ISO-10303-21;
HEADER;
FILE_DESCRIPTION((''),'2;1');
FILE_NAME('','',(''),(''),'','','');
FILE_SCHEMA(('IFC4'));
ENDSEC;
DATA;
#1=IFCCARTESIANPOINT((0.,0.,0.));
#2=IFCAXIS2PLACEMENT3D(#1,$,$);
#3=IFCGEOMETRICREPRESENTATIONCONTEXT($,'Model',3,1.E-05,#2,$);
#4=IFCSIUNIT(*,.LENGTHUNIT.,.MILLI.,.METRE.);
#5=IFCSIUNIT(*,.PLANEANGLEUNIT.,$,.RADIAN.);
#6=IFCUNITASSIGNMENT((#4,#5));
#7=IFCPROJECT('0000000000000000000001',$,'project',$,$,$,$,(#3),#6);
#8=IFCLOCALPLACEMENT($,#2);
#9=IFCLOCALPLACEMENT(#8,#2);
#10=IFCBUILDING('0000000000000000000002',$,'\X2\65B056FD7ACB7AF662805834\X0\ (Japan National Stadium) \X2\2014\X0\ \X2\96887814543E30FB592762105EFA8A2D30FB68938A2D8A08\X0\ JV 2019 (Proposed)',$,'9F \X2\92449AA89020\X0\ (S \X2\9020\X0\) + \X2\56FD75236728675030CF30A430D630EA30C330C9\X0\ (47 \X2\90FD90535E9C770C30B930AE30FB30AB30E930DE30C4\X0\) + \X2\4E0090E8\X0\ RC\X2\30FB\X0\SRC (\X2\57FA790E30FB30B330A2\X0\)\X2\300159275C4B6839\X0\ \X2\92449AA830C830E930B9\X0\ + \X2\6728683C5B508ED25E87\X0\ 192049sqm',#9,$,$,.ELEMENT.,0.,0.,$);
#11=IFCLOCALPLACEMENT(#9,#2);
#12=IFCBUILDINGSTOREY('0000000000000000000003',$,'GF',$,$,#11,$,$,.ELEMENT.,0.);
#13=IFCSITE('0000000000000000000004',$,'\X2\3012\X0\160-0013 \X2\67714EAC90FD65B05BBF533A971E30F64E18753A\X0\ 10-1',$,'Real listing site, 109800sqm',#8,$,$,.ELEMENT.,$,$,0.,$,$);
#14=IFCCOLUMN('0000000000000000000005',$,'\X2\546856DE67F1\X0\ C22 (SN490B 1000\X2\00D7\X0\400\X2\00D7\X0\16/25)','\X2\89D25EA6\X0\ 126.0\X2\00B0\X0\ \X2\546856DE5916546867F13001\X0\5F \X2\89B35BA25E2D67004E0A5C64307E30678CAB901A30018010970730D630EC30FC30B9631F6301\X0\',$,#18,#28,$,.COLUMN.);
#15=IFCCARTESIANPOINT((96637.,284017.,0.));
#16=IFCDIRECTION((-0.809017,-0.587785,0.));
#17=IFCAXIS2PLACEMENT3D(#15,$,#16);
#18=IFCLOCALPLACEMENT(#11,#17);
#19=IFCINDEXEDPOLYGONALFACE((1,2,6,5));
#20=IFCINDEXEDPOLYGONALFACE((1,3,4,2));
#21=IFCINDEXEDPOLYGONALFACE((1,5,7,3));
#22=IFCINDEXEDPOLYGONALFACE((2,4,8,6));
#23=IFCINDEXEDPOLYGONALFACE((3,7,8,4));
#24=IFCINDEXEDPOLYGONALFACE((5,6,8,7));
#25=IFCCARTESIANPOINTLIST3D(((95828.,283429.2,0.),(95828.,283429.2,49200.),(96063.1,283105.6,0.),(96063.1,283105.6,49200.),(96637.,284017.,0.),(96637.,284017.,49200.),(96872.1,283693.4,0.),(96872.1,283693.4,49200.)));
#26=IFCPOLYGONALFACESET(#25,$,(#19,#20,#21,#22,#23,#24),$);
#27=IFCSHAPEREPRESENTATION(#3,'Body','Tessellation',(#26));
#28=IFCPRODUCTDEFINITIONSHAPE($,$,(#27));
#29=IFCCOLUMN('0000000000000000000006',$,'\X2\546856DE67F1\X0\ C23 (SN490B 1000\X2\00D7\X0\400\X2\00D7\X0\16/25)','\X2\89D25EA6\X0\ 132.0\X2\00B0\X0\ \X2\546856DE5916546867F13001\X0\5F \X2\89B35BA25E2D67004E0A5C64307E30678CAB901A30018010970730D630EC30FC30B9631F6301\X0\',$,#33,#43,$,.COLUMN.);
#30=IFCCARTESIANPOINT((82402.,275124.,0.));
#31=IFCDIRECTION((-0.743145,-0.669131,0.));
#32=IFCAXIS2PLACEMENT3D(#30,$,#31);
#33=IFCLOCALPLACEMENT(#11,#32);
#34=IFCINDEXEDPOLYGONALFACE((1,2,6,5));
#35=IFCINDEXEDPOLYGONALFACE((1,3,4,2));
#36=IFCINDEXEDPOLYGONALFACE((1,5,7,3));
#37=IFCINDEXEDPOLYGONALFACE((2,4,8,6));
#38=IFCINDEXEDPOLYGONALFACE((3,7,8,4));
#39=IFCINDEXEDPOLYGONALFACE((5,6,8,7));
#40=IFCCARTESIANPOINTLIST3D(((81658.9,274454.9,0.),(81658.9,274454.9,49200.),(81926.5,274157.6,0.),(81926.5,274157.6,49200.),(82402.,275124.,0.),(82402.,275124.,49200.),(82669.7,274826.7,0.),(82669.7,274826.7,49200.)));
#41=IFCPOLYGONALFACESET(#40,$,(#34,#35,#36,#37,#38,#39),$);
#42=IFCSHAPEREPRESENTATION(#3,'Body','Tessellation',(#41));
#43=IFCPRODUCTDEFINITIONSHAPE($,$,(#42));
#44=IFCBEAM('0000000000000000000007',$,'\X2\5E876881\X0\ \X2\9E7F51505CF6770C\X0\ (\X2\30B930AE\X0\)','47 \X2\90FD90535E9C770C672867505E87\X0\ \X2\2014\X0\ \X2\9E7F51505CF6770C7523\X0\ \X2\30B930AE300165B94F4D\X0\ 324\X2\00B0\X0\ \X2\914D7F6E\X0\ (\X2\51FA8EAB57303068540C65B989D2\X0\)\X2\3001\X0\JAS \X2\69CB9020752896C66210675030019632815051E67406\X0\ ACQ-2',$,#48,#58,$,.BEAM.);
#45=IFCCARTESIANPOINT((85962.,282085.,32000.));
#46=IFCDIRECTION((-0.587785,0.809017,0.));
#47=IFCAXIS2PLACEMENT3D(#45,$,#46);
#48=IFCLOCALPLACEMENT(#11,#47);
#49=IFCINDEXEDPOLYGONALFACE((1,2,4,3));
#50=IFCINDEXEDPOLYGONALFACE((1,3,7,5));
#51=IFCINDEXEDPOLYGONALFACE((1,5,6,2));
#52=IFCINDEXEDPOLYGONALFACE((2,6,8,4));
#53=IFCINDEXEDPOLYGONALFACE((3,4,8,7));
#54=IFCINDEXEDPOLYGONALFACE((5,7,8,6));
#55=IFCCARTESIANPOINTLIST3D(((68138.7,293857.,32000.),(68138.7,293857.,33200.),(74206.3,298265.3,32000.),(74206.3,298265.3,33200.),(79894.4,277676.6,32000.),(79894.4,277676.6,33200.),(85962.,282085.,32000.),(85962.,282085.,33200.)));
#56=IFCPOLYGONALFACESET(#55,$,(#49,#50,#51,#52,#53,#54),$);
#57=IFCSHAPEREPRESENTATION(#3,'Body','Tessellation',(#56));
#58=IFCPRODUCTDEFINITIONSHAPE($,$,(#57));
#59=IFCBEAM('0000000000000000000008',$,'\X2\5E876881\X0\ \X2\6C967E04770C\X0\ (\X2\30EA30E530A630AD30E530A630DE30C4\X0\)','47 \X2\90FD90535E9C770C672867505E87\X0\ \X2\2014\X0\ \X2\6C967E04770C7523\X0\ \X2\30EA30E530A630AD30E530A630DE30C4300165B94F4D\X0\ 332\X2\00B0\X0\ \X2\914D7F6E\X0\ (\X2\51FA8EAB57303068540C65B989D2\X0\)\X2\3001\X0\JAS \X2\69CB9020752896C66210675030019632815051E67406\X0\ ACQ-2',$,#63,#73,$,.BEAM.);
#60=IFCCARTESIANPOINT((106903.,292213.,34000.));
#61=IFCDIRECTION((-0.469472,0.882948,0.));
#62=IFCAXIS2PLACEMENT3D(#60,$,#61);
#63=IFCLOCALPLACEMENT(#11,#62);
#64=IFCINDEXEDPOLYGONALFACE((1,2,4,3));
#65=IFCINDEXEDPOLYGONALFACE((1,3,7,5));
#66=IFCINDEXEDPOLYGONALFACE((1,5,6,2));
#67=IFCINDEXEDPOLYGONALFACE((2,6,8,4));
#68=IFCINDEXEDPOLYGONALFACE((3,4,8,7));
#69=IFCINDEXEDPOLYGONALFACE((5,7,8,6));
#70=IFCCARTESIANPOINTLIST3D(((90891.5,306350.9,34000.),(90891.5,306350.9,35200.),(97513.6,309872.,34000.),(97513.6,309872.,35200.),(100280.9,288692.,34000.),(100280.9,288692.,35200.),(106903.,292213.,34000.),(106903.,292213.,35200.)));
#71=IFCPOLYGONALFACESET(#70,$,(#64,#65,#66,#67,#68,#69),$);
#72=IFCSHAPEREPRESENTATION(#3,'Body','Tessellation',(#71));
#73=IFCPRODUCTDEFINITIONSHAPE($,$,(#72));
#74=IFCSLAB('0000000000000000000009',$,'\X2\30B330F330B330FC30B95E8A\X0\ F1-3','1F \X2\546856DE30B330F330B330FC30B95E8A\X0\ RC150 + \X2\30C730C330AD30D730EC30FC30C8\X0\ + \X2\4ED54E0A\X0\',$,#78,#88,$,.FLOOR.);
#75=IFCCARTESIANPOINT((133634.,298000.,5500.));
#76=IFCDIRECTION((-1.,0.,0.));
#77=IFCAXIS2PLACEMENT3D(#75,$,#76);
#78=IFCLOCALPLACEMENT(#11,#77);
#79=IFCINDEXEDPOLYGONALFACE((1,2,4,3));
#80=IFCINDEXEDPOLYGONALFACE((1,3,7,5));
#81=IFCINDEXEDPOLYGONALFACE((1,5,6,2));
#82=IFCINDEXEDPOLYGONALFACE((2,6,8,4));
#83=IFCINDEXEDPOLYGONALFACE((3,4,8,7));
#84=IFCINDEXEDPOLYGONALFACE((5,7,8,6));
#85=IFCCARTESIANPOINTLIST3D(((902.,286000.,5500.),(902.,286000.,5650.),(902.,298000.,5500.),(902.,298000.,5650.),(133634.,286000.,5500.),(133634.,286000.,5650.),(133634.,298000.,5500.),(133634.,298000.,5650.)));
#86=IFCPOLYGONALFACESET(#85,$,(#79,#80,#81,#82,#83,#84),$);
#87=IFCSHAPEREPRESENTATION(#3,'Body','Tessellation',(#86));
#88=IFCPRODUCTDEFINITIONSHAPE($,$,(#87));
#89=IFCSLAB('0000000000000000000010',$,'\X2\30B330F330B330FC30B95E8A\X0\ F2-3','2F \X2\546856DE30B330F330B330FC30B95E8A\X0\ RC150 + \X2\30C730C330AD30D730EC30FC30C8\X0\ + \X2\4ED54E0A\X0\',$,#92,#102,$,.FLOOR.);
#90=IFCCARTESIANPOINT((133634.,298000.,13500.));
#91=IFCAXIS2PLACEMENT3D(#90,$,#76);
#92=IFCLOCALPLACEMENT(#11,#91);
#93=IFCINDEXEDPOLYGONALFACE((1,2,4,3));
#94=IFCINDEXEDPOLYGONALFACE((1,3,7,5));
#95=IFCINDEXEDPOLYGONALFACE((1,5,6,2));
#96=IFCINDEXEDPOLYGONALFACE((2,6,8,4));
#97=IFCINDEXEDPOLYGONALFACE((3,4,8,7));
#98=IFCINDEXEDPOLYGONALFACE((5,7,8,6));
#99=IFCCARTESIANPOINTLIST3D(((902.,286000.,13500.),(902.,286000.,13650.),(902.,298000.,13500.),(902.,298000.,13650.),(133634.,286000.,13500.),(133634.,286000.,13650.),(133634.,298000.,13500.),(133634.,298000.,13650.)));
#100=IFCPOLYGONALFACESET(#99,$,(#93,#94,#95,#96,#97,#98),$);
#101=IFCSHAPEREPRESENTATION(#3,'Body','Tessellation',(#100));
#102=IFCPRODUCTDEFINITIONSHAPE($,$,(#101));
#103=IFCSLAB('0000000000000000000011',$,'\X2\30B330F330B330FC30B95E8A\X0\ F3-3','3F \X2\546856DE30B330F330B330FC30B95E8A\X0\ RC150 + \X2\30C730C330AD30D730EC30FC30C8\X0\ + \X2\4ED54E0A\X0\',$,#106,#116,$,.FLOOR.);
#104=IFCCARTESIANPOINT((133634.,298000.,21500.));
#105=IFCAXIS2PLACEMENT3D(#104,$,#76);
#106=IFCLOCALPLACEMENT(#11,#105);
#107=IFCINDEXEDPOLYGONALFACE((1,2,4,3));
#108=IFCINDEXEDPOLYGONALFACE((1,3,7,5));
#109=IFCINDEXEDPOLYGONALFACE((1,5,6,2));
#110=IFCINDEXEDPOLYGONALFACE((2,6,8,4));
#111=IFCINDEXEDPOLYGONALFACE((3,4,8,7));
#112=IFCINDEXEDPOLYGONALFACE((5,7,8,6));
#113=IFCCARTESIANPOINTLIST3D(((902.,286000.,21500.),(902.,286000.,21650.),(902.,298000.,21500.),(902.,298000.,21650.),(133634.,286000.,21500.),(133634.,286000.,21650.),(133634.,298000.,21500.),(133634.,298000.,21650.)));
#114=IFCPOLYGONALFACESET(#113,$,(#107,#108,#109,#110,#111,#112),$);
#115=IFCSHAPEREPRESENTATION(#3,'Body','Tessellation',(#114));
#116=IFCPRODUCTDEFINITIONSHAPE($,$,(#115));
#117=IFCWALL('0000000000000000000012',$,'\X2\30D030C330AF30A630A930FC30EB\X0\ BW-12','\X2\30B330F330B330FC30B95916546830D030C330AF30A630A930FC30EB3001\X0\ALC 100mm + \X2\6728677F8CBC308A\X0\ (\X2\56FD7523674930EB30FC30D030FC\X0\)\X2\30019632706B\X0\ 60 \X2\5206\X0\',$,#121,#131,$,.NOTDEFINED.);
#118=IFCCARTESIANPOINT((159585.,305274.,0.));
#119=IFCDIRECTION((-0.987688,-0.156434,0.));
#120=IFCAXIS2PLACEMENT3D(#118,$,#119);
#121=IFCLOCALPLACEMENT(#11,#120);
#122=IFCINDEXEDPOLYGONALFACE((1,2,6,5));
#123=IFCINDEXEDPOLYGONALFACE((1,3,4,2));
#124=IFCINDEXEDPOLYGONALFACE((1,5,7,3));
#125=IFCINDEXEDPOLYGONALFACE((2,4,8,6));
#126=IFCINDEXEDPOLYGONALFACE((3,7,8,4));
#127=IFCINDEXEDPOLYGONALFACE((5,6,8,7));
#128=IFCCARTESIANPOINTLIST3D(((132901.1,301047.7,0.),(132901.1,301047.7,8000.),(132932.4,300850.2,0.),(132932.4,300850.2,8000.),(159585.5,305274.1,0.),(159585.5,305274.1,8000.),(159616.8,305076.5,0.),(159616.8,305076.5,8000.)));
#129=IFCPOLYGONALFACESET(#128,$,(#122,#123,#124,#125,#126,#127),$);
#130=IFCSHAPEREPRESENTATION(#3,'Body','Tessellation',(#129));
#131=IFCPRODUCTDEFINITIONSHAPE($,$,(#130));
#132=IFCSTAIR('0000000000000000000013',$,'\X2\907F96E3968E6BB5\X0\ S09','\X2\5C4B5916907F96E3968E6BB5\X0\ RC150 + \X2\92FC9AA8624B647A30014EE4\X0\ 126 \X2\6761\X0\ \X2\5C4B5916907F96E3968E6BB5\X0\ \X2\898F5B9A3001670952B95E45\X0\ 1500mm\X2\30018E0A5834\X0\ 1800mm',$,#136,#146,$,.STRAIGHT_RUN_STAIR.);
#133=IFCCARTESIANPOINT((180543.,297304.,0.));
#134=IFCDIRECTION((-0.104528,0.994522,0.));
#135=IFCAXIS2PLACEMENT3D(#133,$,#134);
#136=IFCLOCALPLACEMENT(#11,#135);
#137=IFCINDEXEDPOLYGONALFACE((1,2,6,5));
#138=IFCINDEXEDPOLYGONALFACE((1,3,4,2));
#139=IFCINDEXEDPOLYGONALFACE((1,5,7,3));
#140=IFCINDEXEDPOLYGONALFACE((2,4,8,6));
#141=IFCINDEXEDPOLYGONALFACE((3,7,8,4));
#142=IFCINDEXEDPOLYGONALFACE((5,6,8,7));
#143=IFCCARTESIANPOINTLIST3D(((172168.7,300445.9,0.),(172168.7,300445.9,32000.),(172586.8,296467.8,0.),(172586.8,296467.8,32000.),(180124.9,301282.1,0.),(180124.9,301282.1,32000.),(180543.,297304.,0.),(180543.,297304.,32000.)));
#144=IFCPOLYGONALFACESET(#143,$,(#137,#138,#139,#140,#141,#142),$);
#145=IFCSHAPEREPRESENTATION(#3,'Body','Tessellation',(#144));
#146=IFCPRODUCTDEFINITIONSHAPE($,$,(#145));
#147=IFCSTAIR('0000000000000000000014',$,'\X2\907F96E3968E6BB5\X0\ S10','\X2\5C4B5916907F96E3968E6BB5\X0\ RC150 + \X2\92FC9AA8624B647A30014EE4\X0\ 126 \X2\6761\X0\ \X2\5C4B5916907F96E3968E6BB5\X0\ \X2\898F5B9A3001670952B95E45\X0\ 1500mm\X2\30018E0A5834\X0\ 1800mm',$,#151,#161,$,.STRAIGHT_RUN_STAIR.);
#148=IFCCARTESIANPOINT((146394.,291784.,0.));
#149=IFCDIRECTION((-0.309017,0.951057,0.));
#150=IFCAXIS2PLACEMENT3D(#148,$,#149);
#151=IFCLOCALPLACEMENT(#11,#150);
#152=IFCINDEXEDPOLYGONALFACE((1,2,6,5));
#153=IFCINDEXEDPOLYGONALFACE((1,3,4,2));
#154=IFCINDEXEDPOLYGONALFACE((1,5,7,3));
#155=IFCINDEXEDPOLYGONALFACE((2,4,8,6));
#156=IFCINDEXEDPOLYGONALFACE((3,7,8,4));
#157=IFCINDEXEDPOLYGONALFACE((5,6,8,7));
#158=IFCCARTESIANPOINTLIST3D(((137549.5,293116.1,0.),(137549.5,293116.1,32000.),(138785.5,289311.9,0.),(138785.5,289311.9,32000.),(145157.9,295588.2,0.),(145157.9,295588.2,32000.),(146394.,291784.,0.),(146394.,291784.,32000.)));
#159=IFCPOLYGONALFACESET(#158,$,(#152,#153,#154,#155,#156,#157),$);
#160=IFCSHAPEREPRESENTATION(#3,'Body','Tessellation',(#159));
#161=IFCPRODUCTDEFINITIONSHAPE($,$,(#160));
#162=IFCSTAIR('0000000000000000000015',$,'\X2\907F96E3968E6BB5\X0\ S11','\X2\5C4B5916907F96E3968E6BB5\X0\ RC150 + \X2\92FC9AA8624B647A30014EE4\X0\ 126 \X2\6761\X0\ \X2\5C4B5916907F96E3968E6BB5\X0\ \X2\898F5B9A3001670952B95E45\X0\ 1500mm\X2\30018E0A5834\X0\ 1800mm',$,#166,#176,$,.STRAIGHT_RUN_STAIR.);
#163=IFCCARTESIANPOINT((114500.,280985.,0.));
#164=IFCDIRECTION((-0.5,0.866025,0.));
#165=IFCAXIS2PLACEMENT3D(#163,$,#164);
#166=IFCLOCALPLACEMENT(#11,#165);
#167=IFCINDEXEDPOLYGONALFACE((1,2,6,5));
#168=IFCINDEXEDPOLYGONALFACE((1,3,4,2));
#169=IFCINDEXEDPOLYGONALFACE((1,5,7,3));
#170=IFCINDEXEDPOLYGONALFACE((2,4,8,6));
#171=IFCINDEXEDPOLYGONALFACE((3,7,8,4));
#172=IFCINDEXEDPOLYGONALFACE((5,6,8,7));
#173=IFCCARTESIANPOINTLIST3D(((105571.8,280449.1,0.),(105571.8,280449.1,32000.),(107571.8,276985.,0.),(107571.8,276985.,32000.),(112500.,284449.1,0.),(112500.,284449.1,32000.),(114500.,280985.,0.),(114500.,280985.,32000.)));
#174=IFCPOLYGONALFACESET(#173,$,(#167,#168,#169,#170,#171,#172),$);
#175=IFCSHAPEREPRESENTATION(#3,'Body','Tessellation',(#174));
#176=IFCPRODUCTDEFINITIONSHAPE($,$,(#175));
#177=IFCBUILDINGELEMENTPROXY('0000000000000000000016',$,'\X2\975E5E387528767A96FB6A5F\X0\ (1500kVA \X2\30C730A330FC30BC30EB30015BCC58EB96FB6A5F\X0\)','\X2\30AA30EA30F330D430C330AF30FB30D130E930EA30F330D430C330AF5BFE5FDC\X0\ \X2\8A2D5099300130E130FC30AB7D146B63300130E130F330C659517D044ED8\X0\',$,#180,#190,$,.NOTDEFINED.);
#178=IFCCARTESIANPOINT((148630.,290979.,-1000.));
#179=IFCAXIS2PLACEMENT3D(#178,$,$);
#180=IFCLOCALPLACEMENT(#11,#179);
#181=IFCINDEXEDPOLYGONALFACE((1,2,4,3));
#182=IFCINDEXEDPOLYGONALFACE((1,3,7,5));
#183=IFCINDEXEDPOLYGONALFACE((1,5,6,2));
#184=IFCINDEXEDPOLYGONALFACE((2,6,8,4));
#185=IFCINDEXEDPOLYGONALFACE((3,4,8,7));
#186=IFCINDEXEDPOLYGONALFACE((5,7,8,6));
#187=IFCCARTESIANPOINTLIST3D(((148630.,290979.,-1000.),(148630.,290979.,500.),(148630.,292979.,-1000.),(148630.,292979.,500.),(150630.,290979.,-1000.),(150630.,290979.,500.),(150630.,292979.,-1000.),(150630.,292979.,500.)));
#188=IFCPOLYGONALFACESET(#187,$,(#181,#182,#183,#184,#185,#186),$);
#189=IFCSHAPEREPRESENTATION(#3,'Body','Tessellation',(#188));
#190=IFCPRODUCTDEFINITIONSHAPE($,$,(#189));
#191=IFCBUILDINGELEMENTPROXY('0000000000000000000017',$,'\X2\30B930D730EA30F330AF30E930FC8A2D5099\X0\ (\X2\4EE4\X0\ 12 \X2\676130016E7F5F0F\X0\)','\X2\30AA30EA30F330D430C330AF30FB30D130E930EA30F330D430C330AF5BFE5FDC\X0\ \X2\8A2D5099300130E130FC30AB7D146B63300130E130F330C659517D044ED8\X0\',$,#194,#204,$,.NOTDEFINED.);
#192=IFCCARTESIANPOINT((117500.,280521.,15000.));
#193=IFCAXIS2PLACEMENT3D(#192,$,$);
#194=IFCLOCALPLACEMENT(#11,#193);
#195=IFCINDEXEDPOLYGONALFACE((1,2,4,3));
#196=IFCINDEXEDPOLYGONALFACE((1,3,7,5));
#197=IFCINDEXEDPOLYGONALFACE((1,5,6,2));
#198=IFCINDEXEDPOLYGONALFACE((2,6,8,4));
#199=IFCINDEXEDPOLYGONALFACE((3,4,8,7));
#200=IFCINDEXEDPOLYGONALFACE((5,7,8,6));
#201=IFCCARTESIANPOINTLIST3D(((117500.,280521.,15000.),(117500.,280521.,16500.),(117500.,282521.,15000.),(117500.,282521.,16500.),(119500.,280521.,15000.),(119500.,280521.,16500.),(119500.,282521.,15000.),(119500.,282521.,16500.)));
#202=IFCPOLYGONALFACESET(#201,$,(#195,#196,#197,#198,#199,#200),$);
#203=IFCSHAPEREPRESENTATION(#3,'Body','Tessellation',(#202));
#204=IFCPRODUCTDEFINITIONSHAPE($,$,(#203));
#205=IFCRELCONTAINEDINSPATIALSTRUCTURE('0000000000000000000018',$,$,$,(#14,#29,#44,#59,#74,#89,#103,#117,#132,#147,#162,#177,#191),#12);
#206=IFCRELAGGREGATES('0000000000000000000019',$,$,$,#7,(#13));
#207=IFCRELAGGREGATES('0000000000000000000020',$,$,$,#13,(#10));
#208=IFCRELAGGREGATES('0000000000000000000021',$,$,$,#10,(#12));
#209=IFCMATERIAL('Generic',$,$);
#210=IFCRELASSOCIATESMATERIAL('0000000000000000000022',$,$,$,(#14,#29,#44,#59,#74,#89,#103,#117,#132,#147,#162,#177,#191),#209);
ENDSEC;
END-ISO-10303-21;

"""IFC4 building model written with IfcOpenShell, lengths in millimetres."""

from ifc_helpers import new_model, si_unit, frame, frame_2d, origin, place, context, project, spatial, rectangle, extrude, material, element, save


model = new_model("IFC4")

# Units and contexts
model_context = context("Model", 3, precision=1e-05, world=origin())
ifc_project = project(units=[si_unit("LENGTHUNIT", "METRE", prefix="MILLI"), si_unit("PLANEANGLEUNIT", "RADIAN")], contexts=[model_context])

# Site, building, storey
site_placement = place(None, origin())
site = spatial("IfcSite", under=ifc_project, at=site_placement, Name="〒160-0013 東京都新宿区霞ヶ丘町 10-1", ObjectType="Real listing site, 109800sqm", CompositionType="ELEMENT", RefElevation=0.0)
building_placement = place(site_placement, origin())
building = spatial("IfcBuilding", under=site, at=building_placement, Name="新国立競技場 (Japan National Stadium) — 隈研吾・大成建設・梓設計 JV 2019 (Proposed)", ObjectType="9F 鉄骨造 (S 造) + 国産木材ハイブリッド (47 都道府県スギ・カラマツ) + 一部 RC・SRC (基礎・コア)、大屋根 鉄骨トラス + 木格子軒庇 192049sqm", CompositionType="ELEMENT", ElevationOfRefHeight=0.0, ElevationOfTerrain=0.0)
storey_placement = place(building_placement, origin())
storey = spatial("IfcBuildingStorey", under=building, at=storey_placement, Name="GF", CompositionType="ELEMENT", Elevation=0.0)

# Columns
ifc_material_1 = material(Name="Generic")
column_1_placement = place(storey_placement, frame((96637.0, 284017.0, 0.0), x_axis=(-0.809017, -0.587785, 0.0)))
element("IfcColumn", 1, at=column_1_placement, inside=storey, material=ifc_material_1, Name="周回柱 C22 (SN490B 1000×400×16/25)", Description="角度 126.0° 周回外周柱、5F 観客席最上層まで貫通、耐震ブレース挟持", PredefinedType="COLUMN", context=model_context, shape_type="SweptSolid", body=[
    extrude(rectangle(XDim=1000.0, YDim=400.0, at=frame_2d((500.0, 200.0))), frame((96637.0, 284017.0, 0.0), x_axis=(-0.809017, -0.587785, 0.0)), (0.0, 0.0, 1.0), 49200.0),
])
column_2_placement = place(storey_placement, frame((82402.0, 275124.0, 0.0), x_axis=(-0.743145, -0.669131, 0.0)))
element("IfcColumn", 2, at=column_2_placement, inside=storey, material=ifc_material_1, Name="周回柱 C23 (SN490B 1000×400×16/25)", Description="角度 132.0° 周回外周柱、5F 観客席最上層まで貫通、耐震ブレース挟持", PredefinedType="COLUMN", context=model_context, shape_type="SweptSolid", body=[
    extrude(rectangle(XDim=1000.0, YDim=400.0, at=frame_2d((500.0, 200.0))), frame((82402.0, 275124.0, 0.0), x_axis=(-0.743145, -0.669131, 0.0)), (0.0, 0.0, 1.0), 49200.0),
])

# Beams
beam_1_placement = place(storey_placement, frame((85962.0, 282085.0, 32000.0), x_axis=(-0.587785, 0.809017, 0.0)))
element("IfcBeam", 3, at=beam_1_placement, inside=storey, material=ifc_material_1, Name="庇梁 鹿児島県 (スギ)", Description="47 都道府県木材庇 — 鹿児島県産 スギ、方位 324° 配置 (出身地と同方角)、JAS 構造用集成材、防腐処理 ACQ-2", PredefinedType="BEAM", context=model_context, shape_type="SweptSolid", body=[
    extrude(rectangle(XDim=20000.0, YDim=7500.0, at=frame_2d((10000.0, 3750.0))), frame((85962.0, 282085.0, 32000.0), x_axis=(-0.587785, 0.809017, 0.0)), (0.0, 0.0, 1.0), 1200.0),
])
beam_2_placement = place(storey_placement, frame((106903.0, 292213.0, 34000.0), x_axis=(-0.469472, 0.882948, 0.0)))
element("IfcBeam", 4, at=beam_2_placement, inside=storey, material=ifc_material_1, Name="庇梁 沖縄県 (リュウキュウマツ)", Description="47 都道府県木材庇 — 沖縄県産 リュウキュウマツ、方位 332° 配置 (出身地と同方角)、JAS 構造用集成材、防腐処理 ACQ-2", PredefinedType="BEAM", context=model_context, shape_type="SweptSolid", body=[
    extrude(rectangle(XDim=20000.0, YDim=7500.0, at=frame_2d((10000.0, 3750.0))), frame((106903.0, 292213.0, 34000.0), x_axis=(-0.469472, 0.882948, 0.0)), (0.0, 0.0, 1.0), 1200.0),
])

# Slabs
slab_1_placement = place(storey_placement, frame((133634.0, 298000.0, 5500.0), x_axis=(-1.0, 0.0, 0.0)))
element("IfcSlab", 5, at=slab_1_placement, inside=storey, material=ifc_material_1, Name="コンコース床 F1-3", Description="1F 周回コンコース床 RC150 + デッキプレート + 仕上", PredefinedType="FLOOR", context=model_context, shape_type="SweptSolid", body=[
    extrude(rectangle(XDim=132732.0, YDim=12000.0, at=frame_2d((66366.0, 6000.0))), frame((133634.0, 298000.0, 5500.0), x_axis=(-1.0, 0.0, 0.0)), (0.0, 0.0, 1.0), 150.0),
])
slab_2_placement = place(storey_placement, frame((133634.0, 298000.0, 13500.0), x_axis=(-1.0, 0.0, 0.0)))
element("IfcSlab", 6, at=slab_2_placement, inside=storey, material=ifc_material_1, Name="コンコース床 F2-3", Description="2F 周回コンコース床 RC150 + デッキプレート + 仕上", PredefinedType="FLOOR", context=model_context, shape_type="SweptSolid", body=[
    extrude(rectangle(XDim=132732.0, YDim=12000.0, at=frame_2d((66366.0, 6000.0))), frame((133634.0, 298000.0, 13500.0), x_axis=(-1.0, 0.0, 0.0)), (0.0, 0.0, 1.0), 150.0),
])
slab_3_placement = place(storey_placement, frame((133634.0, 298000.0, 21500.0), x_axis=(-1.0, 0.0, 0.0)))
element("IfcSlab", 7, at=slab_3_placement, inside=storey, material=ifc_material_1, Name="コンコース床 F3-3", Description="3F 周回コンコース床 RC150 + デッキプレート + 仕上", PredefinedType="FLOOR", context=model_context, shape_type="SweptSolid", body=[
    extrude(rectangle(XDim=132732.0, YDim=12000.0, at=frame_2d((66366.0, 6000.0))), frame((133634.0, 298000.0, 21500.0), x_axis=(-1.0, 0.0, 0.0)), (0.0, 0.0, 1.0), 150.0),
])

# Wall
wall_1_placement = place(storey_placement, frame((159585.0, 305274.0, 0.0), x_axis=(-0.987688, -0.156434, 0.0)))
element("IfcWall", 8, at=wall_1_placement, inside=storey, material=ifc_material_1, Name="バックウォール BW-12", Description="コンコース外周バックウォール、ALC 100mm + 木板貼り (国産杉ルーバー)、防火 60 分", PredefinedType="NOTDEFINED", context=model_context, shape_type="SweptSolid", body=[
    extrude(rectangle(XDim=27017.0, YDim=200.0, at=frame_2d((13508.0, 100.0))), frame((159585.0, 305274.0, 0.0), x_axis=(-0.987688, -0.156434, 0.0)), (0.0, 0.0, 1.0), 8000.0),
])

# Stairs
stair_1_placement = place(storey_placement, frame((180543.0, 297304.0, 0.0), x_axis=(-0.104528, 0.994522, 0.0)))
element("IfcStair", 9, at=stair_1_placement, inside=storey, material=ifc_material_1, Name="避難階段 S09", Description="屋外避難階段 RC150 + 鋼骨手摺、令 126 条 屋外避難階段 規定、有効幅 1500mm、踊場 1800mm", PredefinedType="STRAIGHT_RUN_STAIR", context=model_context, shape_type="SweptSolid", body=[
    extrude(rectangle(XDim=4000.0, YDim=8000.0, at=frame_2d((2000.0, 4000.0))), frame((180543.0, 297304.0, 0.0), x_axis=(-0.104528, 0.994522, 0.0)), (0.0, 0.0, 1.0), 32000.0),
])
stair_2_placement = place(storey_placement, frame((146394.0, 291784.0, 0.0), x_axis=(-0.309017, 0.951057, 0.0)))
element("IfcStair", 10, at=stair_2_placement, inside=storey, material=ifc_material_1, Name="避難階段 S10", Description="屋外避難階段 RC150 + 鋼骨手摺、令 126 条 屋外避難階段 規定、有効幅 1500mm、踊場 1800mm", PredefinedType="STRAIGHT_RUN_STAIR", context=model_context, shape_type="SweptSolid", body=[
    extrude(rectangle(XDim=4000.0, YDim=8000.0, at=frame_2d((2000.0, 4000.0))), frame((146394.0, 291784.0, 0.0), x_axis=(-0.309017, 0.951057, 0.0)), (0.0, 0.0, 1.0), 32000.0),
])
stair_3_placement = place(storey_placement, frame((114500.0, 280985.0, 0.0), x_axis=(-0.5, 0.866025, 0.0)))
element("IfcStair", 11, at=stair_3_placement, inside=storey, material=ifc_material_1, Name="避難階段 S11", Description="屋外避難階段 RC150 + 鋼骨手摺、令 126 条 屋外避難階段 規定、有効幅 1500mm、踊場 1800mm", PredefinedType="STRAIGHT_RUN_STAIR", context=model_context, shape_type="SweptSolid", body=[
    extrude(rectangle(XDim=4000.0, YDim=8000.0, at=frame_2d((2000.0, 4000.0))), frame((114500.0, 280985.0, 0.0), x_axis=(-0.5, 0.866025, 0.0)), (0.0, 0.0, 1.0), 32000.0),
])

# Building element proxies
proxy_1_placement = place(storey_placement, frame((148630.0, 290979.0, -1000.0)))
element("IfcBuildingElementProxy", 12, at=proxy_1_placement, inside=storey, material=ifc_material_1, Name="非常用発電機 (1500kVA ディーゼル、富士電機)", Description="オリンピック・パラリンピック対応 設備、メーカ純正、メンテ契約付", PredefinedType="NOTDEFINED", context=model_context, shape_type="SweptSolid", body=[
    extrude(rectangle(XDim=2000.0, YDim=2000.0, at=frame_2d((1000.0, 1000.0))), frame((148630.0, 290979.0, -1000.0)), (0.0, 0.0, 1.0), 1500.0),
])
proxy_2_placement = place(storey_placement, frame((117500.0, 280521.0, 15000.0)))
element("IfcBuildingElementProxy", 13, at=proxy_2_placement, inside=storey, material=ifc_material_1, Name="スプリンクラー設備 (令 12 条、湿式)", Description="オリンピック・パラリンピック対応 設備、メーカ純正、メンテ契約付", PredefinedType="NOTDEFINED", context=model_context, shape_type="SweptSolid", body=[
    extrude(rectangle(XDim=2000.0, YDim=2000.0, at=frame_2d((1000.0, 1000.0))), frame((117500.0, 280521.0, 15000.0)), (0.0, 0.0, 1.0), 1500.0),
])

save(model, "model.ifc")
